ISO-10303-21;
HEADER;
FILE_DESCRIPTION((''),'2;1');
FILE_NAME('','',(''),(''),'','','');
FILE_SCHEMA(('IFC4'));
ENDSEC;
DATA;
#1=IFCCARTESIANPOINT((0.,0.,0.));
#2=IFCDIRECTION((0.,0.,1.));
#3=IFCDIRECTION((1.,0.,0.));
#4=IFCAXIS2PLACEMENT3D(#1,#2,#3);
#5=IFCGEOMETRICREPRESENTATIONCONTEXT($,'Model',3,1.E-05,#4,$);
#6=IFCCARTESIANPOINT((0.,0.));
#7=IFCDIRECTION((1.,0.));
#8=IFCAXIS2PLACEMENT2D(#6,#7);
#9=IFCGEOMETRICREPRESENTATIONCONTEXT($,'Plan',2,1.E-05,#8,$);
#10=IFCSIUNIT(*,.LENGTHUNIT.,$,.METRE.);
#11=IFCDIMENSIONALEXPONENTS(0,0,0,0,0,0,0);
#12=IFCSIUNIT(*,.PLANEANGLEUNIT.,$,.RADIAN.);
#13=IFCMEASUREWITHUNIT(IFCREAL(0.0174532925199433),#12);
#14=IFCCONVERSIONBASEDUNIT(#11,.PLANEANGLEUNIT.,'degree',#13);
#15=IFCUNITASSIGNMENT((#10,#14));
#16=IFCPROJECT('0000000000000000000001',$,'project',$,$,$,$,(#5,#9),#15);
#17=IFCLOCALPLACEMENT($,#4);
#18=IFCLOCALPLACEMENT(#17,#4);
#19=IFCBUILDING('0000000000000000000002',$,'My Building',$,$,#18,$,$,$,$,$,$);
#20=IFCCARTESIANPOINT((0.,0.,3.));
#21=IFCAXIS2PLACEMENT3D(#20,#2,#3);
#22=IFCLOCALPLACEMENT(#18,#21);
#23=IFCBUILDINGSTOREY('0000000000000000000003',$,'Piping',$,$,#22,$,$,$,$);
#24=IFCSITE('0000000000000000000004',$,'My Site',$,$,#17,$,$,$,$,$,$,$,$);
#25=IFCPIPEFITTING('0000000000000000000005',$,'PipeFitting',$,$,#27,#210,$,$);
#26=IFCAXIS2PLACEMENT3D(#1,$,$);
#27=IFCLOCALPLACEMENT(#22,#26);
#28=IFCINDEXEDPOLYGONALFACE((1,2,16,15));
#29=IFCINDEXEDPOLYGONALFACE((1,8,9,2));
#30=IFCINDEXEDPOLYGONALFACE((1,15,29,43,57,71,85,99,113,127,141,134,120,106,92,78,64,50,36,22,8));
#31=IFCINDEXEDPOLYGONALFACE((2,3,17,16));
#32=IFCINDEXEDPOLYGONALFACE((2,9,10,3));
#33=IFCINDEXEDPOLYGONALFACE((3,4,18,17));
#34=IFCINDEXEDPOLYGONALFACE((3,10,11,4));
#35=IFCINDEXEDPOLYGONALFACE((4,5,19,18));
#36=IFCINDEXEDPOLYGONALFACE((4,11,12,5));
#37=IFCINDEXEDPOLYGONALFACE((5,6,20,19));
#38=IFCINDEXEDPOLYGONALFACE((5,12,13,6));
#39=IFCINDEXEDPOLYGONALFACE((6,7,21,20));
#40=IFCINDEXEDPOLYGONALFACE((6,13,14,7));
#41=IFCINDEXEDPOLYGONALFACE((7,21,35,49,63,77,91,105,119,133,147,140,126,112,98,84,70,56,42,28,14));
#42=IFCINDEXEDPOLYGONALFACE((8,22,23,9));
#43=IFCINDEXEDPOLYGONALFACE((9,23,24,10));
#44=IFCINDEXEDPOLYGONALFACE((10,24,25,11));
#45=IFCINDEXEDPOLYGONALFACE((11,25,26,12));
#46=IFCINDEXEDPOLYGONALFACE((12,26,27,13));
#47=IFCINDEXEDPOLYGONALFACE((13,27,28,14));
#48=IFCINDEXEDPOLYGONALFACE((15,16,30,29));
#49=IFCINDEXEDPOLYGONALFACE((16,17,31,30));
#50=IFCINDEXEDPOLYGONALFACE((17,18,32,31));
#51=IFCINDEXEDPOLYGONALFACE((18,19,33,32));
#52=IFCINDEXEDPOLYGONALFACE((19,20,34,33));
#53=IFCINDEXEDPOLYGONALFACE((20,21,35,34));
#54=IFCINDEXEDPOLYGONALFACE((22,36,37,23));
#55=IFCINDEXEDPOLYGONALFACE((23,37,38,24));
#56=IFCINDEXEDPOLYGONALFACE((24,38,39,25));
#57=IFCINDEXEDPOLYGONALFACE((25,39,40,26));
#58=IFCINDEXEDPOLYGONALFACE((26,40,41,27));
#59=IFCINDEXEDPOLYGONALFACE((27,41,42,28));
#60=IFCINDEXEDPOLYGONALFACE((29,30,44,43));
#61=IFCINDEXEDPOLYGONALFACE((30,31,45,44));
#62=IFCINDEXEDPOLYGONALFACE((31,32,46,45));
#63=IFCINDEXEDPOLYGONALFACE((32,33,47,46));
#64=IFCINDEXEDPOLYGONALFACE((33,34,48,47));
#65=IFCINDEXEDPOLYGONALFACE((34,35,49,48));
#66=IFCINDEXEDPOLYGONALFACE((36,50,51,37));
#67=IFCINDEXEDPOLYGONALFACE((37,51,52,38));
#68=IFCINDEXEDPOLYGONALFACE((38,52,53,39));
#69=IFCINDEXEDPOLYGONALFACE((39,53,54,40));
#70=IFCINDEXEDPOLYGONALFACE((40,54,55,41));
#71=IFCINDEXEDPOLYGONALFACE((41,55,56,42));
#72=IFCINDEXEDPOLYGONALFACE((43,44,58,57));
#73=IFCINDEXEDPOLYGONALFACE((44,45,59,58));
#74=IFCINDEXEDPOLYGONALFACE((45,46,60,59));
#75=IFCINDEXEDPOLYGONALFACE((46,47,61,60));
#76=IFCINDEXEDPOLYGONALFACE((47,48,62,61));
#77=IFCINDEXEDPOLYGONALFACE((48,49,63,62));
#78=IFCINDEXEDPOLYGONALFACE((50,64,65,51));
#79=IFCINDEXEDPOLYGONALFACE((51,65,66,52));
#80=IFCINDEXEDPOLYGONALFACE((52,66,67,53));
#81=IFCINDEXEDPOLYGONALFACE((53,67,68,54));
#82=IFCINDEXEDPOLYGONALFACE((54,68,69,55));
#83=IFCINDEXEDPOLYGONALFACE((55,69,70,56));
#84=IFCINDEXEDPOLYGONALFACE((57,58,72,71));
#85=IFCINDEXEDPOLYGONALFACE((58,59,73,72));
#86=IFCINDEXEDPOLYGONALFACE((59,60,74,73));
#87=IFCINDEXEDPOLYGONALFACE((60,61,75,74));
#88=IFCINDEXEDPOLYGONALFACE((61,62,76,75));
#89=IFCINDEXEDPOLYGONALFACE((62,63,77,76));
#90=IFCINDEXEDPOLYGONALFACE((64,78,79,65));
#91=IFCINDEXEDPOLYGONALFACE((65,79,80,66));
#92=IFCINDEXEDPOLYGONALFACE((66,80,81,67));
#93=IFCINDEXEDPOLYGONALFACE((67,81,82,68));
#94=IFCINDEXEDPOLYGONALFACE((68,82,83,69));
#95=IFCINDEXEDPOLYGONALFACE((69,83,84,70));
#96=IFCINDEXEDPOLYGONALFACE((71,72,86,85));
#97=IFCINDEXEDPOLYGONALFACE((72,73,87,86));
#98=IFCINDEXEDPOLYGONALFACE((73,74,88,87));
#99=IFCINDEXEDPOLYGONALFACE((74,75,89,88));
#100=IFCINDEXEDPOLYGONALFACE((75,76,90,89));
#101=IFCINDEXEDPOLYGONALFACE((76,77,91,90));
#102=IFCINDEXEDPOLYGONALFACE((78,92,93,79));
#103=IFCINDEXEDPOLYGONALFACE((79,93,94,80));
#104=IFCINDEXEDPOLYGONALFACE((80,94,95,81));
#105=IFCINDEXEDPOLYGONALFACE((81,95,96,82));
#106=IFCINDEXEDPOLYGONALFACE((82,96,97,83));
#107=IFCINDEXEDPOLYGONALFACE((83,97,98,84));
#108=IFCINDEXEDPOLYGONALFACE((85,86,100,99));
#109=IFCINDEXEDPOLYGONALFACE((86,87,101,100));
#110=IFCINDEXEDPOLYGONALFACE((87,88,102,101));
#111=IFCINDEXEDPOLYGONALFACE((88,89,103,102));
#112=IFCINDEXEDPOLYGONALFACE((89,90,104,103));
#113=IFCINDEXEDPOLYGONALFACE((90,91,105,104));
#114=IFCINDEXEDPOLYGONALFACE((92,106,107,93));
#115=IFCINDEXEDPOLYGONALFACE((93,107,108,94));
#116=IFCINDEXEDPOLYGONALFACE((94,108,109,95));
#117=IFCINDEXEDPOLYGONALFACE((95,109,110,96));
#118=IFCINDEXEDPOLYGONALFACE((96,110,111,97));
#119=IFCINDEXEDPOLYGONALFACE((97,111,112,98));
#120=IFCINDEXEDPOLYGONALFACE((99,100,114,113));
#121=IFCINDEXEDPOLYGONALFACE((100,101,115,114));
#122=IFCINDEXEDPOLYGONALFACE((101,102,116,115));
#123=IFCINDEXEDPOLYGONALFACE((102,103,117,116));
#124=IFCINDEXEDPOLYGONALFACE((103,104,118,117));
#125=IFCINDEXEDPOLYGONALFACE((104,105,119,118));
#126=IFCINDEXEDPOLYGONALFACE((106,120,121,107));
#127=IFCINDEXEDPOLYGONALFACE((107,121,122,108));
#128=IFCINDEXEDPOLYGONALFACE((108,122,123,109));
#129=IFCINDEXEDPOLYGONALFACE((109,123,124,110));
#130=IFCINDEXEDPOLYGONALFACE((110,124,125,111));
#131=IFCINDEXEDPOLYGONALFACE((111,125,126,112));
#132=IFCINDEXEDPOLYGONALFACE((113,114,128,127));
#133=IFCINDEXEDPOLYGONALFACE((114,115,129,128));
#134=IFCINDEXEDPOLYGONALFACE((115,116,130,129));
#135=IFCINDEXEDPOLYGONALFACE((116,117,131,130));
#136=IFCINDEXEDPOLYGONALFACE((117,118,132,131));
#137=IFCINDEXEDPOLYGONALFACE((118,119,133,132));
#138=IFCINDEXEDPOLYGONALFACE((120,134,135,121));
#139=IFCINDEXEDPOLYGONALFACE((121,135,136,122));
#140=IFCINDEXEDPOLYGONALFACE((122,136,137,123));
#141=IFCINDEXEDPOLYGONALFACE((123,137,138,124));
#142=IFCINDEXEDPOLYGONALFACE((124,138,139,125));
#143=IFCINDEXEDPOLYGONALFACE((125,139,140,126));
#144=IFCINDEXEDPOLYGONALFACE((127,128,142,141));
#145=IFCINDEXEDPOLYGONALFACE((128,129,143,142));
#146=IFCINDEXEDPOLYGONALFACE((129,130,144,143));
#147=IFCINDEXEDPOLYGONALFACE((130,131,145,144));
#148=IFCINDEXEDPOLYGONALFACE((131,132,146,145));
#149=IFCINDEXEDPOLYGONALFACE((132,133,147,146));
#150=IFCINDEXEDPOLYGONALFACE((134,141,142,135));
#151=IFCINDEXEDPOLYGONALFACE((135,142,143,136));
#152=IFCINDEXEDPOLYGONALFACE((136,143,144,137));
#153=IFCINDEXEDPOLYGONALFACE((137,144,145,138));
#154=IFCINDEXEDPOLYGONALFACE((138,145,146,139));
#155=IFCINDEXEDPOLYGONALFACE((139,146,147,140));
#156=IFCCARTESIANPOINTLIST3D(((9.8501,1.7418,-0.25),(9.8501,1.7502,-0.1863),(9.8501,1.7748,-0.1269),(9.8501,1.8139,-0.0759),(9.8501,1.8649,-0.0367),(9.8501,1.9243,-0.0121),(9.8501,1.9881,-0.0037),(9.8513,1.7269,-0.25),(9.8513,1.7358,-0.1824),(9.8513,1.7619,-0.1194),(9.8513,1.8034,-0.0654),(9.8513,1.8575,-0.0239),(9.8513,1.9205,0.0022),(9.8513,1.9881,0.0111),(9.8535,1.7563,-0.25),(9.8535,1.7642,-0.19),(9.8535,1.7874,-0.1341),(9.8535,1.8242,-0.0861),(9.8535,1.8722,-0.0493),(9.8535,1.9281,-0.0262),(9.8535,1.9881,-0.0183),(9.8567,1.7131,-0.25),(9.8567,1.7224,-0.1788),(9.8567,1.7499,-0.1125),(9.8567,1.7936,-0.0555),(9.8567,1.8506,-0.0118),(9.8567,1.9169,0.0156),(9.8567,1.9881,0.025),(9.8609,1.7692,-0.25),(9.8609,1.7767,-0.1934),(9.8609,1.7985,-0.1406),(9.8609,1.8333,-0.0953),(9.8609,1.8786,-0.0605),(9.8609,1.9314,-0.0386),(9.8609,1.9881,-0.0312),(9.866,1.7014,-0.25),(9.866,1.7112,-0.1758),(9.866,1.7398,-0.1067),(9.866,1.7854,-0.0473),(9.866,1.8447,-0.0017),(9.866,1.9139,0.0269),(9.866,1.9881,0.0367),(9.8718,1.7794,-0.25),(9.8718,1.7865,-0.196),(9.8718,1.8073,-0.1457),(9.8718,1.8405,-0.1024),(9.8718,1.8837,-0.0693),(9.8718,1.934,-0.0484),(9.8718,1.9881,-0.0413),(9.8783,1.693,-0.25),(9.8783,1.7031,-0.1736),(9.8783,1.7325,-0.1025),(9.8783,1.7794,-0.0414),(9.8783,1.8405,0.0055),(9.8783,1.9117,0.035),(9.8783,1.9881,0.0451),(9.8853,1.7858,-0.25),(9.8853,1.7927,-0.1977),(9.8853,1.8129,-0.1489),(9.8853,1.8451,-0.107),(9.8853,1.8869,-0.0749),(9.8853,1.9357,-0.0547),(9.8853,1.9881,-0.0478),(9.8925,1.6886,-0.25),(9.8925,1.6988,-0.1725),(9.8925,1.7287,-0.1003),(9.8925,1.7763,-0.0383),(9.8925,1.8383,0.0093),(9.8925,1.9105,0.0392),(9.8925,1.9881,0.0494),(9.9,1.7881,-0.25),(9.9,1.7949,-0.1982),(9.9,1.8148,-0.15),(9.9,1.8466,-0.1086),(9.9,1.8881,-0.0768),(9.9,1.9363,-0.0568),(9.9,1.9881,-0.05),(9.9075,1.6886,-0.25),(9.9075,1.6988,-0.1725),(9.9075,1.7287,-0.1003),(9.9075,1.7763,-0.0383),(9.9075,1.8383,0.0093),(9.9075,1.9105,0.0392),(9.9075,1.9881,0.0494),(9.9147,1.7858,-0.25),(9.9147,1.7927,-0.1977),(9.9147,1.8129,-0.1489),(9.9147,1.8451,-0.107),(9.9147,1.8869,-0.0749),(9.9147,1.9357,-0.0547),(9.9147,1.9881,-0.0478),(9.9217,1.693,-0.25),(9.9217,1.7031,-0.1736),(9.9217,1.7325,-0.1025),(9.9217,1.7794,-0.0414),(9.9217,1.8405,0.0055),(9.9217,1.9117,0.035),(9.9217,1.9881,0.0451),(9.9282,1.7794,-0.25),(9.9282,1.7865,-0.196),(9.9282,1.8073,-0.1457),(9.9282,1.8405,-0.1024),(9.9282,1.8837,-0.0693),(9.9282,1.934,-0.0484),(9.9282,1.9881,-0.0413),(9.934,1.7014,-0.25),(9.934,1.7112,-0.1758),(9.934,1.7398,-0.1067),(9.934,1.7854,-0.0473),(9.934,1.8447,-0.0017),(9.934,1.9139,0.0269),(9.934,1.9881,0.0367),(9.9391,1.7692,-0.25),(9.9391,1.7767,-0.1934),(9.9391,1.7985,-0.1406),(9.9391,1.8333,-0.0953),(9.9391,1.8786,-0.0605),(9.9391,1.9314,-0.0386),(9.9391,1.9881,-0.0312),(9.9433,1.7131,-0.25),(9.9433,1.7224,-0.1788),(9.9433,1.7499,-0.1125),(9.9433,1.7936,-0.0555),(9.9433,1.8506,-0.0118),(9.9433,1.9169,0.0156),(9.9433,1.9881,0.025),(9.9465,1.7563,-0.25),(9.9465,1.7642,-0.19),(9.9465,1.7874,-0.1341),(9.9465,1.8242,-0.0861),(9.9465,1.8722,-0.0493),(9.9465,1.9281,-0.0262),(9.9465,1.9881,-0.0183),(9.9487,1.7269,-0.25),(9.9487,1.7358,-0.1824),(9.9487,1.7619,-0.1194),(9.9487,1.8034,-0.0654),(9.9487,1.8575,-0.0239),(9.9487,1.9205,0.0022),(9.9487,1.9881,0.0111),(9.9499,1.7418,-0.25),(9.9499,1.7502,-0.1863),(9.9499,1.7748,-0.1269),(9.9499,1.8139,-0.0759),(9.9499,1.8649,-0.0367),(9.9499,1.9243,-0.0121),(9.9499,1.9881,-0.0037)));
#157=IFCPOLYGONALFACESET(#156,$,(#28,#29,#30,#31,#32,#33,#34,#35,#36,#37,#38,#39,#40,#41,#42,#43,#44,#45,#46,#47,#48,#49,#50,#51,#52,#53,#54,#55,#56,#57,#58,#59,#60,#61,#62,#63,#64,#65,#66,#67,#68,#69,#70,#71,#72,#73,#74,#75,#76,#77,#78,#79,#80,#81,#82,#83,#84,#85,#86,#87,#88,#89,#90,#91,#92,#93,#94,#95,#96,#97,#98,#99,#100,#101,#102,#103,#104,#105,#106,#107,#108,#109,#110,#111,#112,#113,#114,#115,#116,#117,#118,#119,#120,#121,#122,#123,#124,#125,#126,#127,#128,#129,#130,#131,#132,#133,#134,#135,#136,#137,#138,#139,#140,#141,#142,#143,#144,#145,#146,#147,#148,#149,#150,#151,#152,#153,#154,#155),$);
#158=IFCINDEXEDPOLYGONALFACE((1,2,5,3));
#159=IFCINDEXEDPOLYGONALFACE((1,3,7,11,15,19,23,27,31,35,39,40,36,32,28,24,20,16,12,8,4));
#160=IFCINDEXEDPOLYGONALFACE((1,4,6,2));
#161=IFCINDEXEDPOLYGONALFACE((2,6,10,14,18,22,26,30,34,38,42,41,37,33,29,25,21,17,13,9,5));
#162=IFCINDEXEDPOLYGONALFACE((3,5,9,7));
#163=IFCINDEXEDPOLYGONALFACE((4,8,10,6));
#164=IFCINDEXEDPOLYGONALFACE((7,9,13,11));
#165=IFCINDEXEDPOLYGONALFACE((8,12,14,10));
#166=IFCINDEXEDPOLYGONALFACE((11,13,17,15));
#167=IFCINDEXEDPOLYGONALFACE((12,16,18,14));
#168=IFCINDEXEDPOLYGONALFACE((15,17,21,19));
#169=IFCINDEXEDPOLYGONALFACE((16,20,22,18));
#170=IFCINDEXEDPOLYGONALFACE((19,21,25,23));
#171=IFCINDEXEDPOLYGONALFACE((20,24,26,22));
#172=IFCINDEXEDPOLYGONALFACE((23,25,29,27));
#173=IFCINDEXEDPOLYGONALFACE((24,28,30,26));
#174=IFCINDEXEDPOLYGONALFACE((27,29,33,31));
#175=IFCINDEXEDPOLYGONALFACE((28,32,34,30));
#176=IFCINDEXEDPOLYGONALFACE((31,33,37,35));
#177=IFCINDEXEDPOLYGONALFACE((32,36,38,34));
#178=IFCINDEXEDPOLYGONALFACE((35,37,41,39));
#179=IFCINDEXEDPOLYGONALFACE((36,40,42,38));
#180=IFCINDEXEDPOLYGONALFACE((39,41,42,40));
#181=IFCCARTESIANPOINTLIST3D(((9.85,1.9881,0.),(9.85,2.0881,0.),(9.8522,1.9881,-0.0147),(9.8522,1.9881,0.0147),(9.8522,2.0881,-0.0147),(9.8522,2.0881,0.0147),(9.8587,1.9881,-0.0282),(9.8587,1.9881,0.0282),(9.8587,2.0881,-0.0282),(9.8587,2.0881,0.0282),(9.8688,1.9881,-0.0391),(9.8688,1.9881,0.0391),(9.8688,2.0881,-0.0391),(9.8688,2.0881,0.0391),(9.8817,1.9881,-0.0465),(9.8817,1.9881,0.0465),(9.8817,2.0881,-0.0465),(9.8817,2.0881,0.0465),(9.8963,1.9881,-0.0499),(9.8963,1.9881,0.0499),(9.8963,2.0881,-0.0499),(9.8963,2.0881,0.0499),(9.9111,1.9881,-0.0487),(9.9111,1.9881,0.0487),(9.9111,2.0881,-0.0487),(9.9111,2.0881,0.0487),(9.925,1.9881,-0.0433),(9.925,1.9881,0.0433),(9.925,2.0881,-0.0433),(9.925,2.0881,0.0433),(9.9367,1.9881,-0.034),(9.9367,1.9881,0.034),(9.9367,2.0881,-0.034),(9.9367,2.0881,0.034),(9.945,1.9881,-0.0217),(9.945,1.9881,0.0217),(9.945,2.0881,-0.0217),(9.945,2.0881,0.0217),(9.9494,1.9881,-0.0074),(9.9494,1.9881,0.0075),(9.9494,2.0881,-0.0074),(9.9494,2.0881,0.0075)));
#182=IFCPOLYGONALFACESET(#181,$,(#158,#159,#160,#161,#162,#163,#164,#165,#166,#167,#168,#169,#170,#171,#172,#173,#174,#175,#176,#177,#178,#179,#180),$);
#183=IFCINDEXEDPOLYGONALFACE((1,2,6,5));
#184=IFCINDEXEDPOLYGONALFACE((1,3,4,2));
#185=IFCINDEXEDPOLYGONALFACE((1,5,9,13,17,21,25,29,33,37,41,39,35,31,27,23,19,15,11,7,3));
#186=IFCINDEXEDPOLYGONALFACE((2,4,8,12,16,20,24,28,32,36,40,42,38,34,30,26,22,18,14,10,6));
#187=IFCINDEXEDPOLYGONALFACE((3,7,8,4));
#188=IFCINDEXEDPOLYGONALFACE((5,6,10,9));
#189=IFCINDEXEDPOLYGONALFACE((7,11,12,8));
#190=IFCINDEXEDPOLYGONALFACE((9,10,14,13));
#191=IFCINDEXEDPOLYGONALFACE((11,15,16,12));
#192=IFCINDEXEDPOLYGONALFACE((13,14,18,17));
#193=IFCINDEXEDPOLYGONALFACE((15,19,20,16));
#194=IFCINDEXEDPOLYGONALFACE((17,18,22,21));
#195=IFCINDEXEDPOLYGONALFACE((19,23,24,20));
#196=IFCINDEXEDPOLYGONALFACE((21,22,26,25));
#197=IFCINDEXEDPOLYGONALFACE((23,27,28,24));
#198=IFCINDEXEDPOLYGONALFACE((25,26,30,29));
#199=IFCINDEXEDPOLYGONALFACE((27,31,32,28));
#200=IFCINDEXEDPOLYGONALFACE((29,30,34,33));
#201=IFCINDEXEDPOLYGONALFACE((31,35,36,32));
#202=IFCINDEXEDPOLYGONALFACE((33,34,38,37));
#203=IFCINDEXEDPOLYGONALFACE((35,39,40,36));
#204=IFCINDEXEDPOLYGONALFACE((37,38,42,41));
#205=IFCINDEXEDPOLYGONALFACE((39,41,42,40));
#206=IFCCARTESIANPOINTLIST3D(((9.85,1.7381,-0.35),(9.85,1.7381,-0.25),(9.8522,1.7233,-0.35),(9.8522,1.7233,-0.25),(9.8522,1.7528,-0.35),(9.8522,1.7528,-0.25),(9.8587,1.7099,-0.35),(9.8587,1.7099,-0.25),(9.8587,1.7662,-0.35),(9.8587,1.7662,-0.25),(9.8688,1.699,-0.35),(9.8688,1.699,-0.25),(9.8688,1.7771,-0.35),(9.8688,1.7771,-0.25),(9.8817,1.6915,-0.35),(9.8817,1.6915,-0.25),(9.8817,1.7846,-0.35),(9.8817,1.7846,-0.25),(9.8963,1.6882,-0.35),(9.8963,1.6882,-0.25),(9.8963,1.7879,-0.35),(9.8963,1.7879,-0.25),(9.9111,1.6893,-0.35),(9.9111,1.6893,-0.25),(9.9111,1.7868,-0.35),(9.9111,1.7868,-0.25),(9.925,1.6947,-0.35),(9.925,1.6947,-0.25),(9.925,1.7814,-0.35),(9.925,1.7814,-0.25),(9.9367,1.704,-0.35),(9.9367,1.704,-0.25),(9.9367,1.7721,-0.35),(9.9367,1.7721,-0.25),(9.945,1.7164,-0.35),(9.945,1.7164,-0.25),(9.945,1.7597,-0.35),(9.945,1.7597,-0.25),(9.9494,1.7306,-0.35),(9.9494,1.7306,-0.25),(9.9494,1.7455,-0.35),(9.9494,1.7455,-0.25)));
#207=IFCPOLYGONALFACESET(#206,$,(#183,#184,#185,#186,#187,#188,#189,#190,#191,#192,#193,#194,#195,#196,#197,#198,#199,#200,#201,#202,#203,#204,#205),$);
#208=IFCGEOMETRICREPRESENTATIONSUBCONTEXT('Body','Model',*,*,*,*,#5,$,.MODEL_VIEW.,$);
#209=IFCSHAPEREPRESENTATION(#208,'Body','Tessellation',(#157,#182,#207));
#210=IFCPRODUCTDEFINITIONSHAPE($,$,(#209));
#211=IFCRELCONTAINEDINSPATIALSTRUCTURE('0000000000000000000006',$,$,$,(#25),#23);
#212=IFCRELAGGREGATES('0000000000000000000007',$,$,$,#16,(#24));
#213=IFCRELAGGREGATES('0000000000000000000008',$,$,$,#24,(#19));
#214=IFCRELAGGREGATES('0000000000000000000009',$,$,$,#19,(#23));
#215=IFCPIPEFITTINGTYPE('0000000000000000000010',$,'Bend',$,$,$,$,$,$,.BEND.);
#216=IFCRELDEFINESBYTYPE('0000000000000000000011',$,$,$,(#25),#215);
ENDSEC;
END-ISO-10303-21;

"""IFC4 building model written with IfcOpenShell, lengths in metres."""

from ifc_helpers import new_model, entity, si_unit, converted_unit, frame, origin_with_axes, origin_2d_with_axis, place, context, subcontext, project, spatial, circle, extrude, source, transform, mapped, type_object, type_shapes, element, save


model = new_model("IFC4")

# Units and contexts
model_context = context("Model", 3, precision=1e-05, world=origin_with_axes())
plan_context = context("Plan", 2, precision=1e-05, world=origin_2d_with_axis())
body_context = subcontext(model_context, "Body", "Model", "MODEL_VIEW")
ifc_project = project(units=[si_unit("LENGTHUNIT", "METRE"), converted_unit("PLANEANGLEUNIT", "degree", entity("IfcReal", 0.0174532925199433), si_unit("PLANEANGLEUNIT", "RADIAN"), dimensions=[0, 0, 0, 0, 0, 0, 0])], contexts=[model_context, plan_context])

# Site, building, storey
site_placement = place(None, origin_with_axes())
site = spatial("IfcSite", under=ifc_project, at=site_placement, Name="My Site")
building_placement = place(site_placement, origin_with_axes())
building = spatial("IfcBuilding", under=site, at=building_placement, Name="My Building")
storey_placement = place(building_placement, frame((0.0, 0.0, 3.0), z_axis=(0.0, 0.0, 1.0), x_axis=(1.0, 0.0, 0.0)))
storey = spatial("IfcBuildingStorey", under=building, at=storey_placement, Name="Piping")

# Pipe fitting
pipe_fitting_type = type_object("IfcPipeFittingType", Name="Bend", PredefinedType="BEND")
shared_shape = source(origin_with_axes(), body_context, "Body", "SolidModel", [
    entity("IfcSweptDiskSolid", entity("IfcIndexedPolyCurve", entity("IfcCartesianPointList3D", [[0.0, 0.0, -0.1], [0.0, -0.0732, -0.2768], [0.0, -0.25, -0.35]]), [entity("IfcArcIndex", [1, 2, 3])]), 0.05),
    extrude(circle(Radius=0.05), origin_with_axes(), (0.0, 0.0, -1.0), 0.1),
    extrude(circle(Radius=0.05), frame((0.0, -0.25, -0.35), z_axis=(0.0, -1.0, 0.0), x_axis=(1.0, 0.0, 0.0)), (0.0, 0.0, 1.0), 0.1),
])
type_shapes(pipe_fitting_type, [shared_shape])
for number, where, z_axis, x_axis, name in (
    (1, (9.9, 2.0881, 0.0), (0.0, 1.0, 0.0), (-1.0, 0.0, 0.0), "PipeFitting"),
):
    element("IfcPipeFitting", number, at=place(storey_placement, frame(where, z_axis=z_axis, x_axis=x_axis)), inside=storey, type_object=pipe_fitting_type, Name=name, context=body_context, shape_type="MappedRepresentation", body=[
        mapped(shared_shape, transform((0.0, 0.0, 0.0), x_axis=(1.0, 0.0, 0.0), y_axis=(0.0, 1.0, 0.0), z_axis=(0.0, 0.0, 1.0), scale=1.0)),
    ])

save(model, "model.ifc")
